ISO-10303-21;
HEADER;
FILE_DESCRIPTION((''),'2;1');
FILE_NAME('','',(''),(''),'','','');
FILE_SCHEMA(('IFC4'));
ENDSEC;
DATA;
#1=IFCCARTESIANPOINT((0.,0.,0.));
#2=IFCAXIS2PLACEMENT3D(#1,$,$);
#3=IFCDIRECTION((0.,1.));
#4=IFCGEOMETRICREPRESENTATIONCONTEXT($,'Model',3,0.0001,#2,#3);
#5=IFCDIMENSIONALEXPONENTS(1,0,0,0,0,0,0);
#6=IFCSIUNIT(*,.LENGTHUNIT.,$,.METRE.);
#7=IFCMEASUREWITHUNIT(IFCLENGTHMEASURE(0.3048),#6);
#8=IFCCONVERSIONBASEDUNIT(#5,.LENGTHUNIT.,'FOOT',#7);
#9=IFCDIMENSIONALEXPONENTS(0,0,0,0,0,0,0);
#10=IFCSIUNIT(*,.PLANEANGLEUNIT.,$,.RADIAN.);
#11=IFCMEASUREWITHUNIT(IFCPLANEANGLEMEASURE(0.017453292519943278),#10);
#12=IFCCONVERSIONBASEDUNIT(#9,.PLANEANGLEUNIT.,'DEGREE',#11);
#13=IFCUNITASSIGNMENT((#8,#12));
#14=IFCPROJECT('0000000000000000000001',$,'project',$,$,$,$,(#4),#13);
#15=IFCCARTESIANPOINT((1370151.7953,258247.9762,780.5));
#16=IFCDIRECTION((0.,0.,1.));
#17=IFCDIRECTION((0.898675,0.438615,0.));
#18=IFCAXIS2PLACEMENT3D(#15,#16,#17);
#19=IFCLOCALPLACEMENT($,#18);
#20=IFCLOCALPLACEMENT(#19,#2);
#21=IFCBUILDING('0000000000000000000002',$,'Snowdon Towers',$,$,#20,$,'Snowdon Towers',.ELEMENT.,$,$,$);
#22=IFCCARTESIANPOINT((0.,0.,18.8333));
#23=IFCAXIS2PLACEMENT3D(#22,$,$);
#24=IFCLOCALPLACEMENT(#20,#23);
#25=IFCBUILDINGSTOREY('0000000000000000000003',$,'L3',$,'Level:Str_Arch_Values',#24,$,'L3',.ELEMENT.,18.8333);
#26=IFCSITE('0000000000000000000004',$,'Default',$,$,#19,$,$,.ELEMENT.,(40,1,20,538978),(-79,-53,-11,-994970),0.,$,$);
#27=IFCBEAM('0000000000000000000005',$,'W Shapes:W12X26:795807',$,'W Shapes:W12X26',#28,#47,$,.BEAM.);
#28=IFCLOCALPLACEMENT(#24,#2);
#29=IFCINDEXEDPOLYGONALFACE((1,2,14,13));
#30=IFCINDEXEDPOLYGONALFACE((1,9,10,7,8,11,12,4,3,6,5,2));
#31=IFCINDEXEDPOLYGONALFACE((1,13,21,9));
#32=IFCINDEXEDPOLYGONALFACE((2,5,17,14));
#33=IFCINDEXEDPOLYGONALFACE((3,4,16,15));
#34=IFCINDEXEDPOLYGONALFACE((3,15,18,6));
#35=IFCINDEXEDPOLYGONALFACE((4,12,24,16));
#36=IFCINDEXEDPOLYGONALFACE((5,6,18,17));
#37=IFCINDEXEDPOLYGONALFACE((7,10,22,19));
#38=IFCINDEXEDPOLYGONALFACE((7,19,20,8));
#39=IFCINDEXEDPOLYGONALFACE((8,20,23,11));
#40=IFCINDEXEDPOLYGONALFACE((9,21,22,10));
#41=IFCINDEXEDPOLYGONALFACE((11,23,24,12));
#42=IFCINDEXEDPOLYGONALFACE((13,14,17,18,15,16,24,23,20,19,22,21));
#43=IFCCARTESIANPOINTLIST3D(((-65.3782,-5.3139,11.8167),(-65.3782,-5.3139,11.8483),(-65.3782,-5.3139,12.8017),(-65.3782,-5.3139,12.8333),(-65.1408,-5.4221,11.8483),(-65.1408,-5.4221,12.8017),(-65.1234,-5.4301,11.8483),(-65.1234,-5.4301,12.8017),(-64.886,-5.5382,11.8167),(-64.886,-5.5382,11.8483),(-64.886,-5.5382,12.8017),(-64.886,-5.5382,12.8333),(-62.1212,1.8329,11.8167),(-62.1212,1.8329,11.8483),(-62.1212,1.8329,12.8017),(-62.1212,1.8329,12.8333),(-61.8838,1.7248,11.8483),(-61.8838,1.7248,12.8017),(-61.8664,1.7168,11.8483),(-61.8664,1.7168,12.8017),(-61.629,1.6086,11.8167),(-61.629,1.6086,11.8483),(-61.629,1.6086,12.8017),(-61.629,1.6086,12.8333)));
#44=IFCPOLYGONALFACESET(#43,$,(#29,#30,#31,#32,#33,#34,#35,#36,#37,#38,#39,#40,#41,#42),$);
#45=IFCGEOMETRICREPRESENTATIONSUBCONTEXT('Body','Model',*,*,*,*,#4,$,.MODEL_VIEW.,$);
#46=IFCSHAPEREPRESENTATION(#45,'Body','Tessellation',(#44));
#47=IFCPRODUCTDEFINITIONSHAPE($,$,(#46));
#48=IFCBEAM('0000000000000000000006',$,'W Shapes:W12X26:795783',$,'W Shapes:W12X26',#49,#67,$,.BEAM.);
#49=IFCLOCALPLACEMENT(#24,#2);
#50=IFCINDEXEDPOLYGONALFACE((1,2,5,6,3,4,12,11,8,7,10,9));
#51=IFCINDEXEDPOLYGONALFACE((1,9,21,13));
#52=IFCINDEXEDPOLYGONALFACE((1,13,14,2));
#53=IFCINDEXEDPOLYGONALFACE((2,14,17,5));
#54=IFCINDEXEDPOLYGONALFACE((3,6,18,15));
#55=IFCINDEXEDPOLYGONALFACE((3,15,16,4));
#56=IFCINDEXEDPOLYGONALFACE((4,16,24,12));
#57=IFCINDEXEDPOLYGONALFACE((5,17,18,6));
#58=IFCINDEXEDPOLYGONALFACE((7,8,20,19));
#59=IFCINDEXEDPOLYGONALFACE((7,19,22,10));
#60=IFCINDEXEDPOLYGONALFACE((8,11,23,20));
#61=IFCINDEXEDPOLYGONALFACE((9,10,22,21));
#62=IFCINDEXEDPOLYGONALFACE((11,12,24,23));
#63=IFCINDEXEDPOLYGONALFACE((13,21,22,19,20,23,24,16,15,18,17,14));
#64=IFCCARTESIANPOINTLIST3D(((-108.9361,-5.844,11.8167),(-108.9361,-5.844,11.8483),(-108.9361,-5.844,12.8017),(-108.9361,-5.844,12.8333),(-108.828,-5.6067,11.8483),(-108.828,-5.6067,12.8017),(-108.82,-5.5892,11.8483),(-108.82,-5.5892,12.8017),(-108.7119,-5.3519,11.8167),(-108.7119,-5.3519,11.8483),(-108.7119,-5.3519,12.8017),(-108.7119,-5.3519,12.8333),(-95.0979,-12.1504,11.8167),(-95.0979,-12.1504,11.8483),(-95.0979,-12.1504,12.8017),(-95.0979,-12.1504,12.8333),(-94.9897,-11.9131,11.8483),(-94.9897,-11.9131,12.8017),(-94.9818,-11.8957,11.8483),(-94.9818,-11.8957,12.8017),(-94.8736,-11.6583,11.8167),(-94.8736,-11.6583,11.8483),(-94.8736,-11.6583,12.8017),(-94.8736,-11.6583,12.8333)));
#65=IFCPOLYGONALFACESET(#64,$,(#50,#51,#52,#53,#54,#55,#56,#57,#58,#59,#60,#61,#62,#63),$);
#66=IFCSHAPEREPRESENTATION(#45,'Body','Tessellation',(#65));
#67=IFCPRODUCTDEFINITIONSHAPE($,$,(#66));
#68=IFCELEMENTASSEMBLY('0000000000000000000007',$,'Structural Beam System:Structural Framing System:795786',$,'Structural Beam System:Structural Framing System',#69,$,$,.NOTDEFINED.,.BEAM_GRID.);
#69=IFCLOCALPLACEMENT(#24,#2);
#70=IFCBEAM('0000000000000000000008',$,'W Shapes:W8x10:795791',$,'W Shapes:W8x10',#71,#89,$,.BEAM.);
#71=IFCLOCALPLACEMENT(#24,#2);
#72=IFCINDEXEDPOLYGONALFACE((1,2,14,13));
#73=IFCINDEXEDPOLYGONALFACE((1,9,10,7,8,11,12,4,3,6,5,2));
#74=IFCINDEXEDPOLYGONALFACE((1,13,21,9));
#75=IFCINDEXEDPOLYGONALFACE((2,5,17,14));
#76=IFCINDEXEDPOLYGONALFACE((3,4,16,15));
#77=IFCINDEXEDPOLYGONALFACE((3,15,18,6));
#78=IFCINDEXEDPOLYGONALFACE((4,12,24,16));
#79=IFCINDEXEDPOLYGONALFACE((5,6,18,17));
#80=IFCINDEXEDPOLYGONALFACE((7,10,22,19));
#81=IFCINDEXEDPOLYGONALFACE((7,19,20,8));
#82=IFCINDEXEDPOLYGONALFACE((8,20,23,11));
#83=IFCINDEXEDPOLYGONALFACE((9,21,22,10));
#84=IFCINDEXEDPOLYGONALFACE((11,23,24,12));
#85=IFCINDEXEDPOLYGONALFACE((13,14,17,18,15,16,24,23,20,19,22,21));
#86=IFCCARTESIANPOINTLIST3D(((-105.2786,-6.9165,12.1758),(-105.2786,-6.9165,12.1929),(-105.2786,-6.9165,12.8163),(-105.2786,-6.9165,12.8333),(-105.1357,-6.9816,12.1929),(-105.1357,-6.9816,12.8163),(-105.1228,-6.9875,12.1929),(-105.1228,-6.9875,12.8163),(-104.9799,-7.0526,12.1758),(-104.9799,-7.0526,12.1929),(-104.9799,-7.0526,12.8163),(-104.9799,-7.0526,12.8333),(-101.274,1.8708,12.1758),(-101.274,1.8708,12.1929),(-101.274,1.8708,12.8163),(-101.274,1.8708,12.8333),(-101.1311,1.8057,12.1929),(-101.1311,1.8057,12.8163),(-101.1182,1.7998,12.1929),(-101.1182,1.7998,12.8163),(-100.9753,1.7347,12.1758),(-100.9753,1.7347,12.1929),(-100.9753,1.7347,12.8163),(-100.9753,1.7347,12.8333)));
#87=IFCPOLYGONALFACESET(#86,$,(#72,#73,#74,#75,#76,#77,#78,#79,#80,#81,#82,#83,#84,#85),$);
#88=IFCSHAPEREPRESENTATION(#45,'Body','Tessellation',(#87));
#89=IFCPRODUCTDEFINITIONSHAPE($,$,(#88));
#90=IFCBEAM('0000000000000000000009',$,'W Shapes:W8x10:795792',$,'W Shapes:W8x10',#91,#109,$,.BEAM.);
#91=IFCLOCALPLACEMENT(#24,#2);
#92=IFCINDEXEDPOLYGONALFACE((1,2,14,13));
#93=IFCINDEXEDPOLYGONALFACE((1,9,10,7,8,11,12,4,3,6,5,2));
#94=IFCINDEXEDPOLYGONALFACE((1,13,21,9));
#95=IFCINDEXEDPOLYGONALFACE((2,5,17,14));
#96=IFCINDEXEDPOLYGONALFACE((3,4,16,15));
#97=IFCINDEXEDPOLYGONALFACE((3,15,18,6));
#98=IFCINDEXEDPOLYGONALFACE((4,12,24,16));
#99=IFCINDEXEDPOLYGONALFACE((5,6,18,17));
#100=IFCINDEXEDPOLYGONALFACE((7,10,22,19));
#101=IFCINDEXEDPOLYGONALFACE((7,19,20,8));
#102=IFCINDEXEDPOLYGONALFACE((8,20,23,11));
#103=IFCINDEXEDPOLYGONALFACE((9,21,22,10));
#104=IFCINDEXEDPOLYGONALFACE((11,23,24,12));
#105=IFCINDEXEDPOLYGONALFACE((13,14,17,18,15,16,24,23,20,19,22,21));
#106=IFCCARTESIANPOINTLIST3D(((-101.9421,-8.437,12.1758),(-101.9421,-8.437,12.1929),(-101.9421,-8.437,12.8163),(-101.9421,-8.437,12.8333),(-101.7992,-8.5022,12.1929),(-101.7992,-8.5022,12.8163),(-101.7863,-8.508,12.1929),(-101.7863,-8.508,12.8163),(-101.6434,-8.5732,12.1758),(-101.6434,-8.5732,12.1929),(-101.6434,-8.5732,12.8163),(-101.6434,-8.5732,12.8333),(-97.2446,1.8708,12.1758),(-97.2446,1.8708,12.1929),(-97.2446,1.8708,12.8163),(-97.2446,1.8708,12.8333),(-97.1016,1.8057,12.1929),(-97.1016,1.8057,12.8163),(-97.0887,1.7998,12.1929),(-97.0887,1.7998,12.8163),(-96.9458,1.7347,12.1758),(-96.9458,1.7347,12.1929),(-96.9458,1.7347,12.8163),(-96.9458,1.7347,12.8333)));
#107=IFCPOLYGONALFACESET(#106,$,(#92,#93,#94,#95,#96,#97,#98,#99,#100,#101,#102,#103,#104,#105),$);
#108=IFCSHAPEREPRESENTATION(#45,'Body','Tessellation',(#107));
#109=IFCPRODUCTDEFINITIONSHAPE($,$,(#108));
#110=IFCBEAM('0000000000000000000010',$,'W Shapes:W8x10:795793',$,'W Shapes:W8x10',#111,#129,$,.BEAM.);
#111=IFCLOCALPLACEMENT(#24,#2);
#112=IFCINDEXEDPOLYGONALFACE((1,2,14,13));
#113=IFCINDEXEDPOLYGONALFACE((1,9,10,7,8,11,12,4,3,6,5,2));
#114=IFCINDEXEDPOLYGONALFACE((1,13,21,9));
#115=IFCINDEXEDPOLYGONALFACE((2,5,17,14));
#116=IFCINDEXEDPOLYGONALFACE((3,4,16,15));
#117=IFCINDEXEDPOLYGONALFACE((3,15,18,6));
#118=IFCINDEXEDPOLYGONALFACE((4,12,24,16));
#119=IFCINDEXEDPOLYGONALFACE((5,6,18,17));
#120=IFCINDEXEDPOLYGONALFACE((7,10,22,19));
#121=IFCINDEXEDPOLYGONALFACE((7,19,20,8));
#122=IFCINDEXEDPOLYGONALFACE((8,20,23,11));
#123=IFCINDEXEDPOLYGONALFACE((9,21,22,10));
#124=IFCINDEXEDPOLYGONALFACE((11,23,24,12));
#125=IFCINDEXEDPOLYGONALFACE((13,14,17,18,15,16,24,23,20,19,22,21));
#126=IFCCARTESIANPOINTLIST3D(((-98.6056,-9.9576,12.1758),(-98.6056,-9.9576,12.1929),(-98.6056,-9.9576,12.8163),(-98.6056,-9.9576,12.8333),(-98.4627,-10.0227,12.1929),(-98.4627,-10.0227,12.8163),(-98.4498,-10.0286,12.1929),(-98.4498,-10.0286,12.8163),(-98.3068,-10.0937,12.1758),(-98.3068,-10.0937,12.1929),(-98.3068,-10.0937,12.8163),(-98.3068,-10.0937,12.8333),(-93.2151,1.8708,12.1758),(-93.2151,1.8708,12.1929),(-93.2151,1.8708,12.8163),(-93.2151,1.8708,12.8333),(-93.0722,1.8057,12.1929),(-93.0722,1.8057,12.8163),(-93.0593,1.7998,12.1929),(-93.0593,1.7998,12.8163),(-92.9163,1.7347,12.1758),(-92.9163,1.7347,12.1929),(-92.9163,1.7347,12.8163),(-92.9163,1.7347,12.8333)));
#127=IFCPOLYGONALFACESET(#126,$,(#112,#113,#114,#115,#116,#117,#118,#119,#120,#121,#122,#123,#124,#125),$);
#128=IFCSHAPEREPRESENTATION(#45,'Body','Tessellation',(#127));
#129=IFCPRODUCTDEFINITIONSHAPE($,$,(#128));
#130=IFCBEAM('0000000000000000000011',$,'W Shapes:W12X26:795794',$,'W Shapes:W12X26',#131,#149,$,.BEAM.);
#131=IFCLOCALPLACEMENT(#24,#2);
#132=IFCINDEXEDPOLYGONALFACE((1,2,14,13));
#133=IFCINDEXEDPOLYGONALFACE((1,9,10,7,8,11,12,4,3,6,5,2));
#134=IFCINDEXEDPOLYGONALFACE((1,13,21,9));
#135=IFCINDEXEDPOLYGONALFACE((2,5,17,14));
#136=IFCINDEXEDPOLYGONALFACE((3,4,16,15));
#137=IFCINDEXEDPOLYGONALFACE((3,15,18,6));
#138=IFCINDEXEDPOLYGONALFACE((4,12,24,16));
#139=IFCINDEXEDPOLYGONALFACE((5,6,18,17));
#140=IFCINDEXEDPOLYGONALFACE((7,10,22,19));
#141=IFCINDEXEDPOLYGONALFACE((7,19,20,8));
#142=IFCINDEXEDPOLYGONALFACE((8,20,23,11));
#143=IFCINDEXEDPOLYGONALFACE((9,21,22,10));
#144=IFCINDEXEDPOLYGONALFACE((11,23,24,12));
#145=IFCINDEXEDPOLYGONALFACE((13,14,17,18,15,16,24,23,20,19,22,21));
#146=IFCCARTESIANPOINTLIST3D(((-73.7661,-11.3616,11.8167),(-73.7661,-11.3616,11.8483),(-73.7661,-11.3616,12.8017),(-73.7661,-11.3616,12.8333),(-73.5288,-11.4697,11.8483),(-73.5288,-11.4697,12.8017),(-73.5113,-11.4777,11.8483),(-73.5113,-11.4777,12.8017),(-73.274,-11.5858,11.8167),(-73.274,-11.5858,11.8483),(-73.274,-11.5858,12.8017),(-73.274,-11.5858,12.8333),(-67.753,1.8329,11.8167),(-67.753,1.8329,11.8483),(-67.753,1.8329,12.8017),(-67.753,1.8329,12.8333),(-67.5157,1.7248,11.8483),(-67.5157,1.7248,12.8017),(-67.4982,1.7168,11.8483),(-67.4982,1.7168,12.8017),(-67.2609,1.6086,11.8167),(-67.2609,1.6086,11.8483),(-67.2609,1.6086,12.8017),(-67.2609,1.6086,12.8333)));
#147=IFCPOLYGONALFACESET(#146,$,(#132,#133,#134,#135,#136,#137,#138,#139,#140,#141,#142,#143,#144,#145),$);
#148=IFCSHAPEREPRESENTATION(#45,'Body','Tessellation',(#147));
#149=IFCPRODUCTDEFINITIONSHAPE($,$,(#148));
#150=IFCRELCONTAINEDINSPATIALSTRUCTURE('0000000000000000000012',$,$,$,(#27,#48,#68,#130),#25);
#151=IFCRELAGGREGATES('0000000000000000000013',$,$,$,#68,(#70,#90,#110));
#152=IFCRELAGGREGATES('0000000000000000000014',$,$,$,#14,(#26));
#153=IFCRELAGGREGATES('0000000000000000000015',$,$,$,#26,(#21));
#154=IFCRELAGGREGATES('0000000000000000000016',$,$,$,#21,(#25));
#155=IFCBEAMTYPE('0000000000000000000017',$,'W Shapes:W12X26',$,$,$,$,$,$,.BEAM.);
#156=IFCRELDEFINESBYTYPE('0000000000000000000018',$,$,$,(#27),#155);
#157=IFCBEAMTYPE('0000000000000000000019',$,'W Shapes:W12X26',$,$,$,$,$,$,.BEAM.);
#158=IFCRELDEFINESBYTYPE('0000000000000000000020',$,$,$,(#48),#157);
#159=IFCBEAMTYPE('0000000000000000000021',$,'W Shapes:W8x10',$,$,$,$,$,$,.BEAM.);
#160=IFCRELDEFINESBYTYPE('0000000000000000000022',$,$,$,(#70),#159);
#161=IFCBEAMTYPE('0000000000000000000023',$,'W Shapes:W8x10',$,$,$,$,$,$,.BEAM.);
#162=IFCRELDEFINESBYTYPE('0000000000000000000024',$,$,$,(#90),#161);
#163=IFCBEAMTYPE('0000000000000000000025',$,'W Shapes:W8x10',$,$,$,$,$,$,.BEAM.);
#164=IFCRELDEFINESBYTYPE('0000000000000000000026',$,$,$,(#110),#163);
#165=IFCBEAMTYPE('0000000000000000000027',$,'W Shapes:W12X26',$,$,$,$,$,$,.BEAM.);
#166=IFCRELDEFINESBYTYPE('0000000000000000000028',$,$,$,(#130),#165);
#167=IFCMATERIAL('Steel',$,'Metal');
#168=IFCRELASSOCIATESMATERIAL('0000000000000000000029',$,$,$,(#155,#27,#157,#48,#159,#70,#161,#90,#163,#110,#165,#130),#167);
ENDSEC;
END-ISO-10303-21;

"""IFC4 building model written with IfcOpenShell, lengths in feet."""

from ifc_helpers import new_model, entity, si_unit, converted_unit, direction, frame, origin, place, context, subcontext, project, spatial, indexed_curve, outline, extrude, source, transform, mapped, material, type_object, type_shapes, element, aggregate, save


model = new_model("IFC4")

# Units and contexts
model_context = context("Model", 3, precision=0.0001, world=origin(), true_north=direction((0.0, 1.0)))
body_context = subcontext(model_context, "Body", "Model", "MODEL_VIEW")
ifc_project = project(units=[converted_unit("LENGTHUNIT", "FOOT", entity("IfcLengthMeasure", 0.3048), si_unit("LENGTHUNIT", "METRE"), dimensions=[1, 0, 0, 0, 0, 0, 0]), converted_unit("PLANEANGLEUNIT", "DEGREE", entity("IfcPlaneAngleMeasure", 0.017453292519943278), si_unit("PLANEANGLEUNIT", "RADIAN"), dimensions=[0, 0, 0, 0, 0, 0, 0])], contexts=[model_context])

# Site, building, storey
site_placement = place(None, frame((1370151.7953, 258247.9762, 780.5), z_axis=(0.0, 0.0, 1.0), x_axis=(0.898675, 0.438615, 0.0)))
site = spatial("IfcSite", under=ifc_project, at=site_placement, Name="Default", CompositionType="ELEMENT", RefLatitude=(40, 1, 20, 538978), RefLongitude=(-79, -53, -11, -994970), RefElevation=0.0)
building_placement = place(site_placement, origin())
building = spatial("IfcBuilding", under=site, at=building_placement, Name="Snowdon Towers", LongName="Snowdon Towers", CompositionType="ELEMENT")
storey_placement = place(building_placement, frame((0.0, 0.0, 18.8333)))
storey = spatial("IfcBuildingStorey", under=building, at=storey_placement, Name="L3", ObjectType="Level:Str_Arch_Values", LongName="L3", CompositionType="ELEMENT", Elevation=18.8333)

# Shared definitions
ifc_material = material(Name="Steel", Category="Metal")

# Beams
beam_type_1 = type_object("IfcBeamType", Name="W Shapes:W12X26", PredefinedType="BEAM", material=ifc_material)
shared_shape_1 = source(origin(), body_context, "Body", "SweptSolid", [
    extrude(outline(indexed_curve([(-0.2704, -0.4767), (-0.2704, -0.5083), (0.2704, -0.5083), (0.2704, -0.4767), (0.0096, -0.4767), (0.0096, 0.4767), (0.2704, 0.4767), (0.2704, 0.5083), (-0.2704, 0.5083), (-0.2704, 0.4767), (-0.0096, 0.4767), (-0.0096, -0.4767), (-0.2704, -0.4767)], self_intersect=False)), frame((-4.1991, 0.0, 0.0), z_axis=(-1.0, 0.0, 0.0), x_axis=(0.0, -1.0, 0.0)), (0.0, 0.0, -1.0), 7.854),
])
type_shapes(beam_type_1, [shared_shape_1])
for number, where, z_axis, x_axis, name in (
    (1, (-63.3907, -1.605, 12.325), (0.0, 0.0, 1.0), (0.414693, 0.909961, 0.0), "W Shapes:W12X26:795807"),
):
    element("IfcBeam", number, at=place(storey_placement, frame(where, z_axis=z_axis, x_axis=x_axis)), inside=storey, type_object=beam_type_1, material=ifc_material, Name=name, ObjectType="W Shapes:W12X26", PredefinedType="BEAM", context=body_context, shape_type="MappedRepresentation", body=[
        mapped(shared_shape_1, transform((0.0, 0.0, 0.0), scale=1.0)),
    ])
beam_type_2 = type_object("IfcBeamType", Name="W Shapes:W12X26", PredefinedType="BEAM", material=ifc_material)
shared_shape_2 = source(origin(), body_context, "Body", "SweptSolid", [
    extrude(outline(indexed_curve([(-0.2704, -0.4767), (-0.2704, -0.5083), (0.2704, -0.5083), (0.2704, -0.4767), (0.0096, -0.4767), (0.0096, 0.4767), (0.2704, 0.4767), (0.2704, 0.5083), (-0.2704, 0.5083), (-0.2704, 0.4767), (-0.0096, 0.4767), (-0.0096, -0.4767), (-0.2704, -0.4767)], self_intersect=False)), frame((-7.6037, 0.0, 0.0), z_axis=(-1.0, 0.0, 0.0), x_axis=(0.0, -1.0, 0.0)), (0.0, 0.0, -1.0), 15.2075),
])
type_shapes(beam_type_2, [shared_shape_2])
beam_1_placement = place(storey_placement, frame((-101.9049, -8.7512, 12.325), z_axis=(0.0, 0.0, 1.0), x_axis=(0.909961, -0.414693, 0.0)))
element("IfcBeam", 2, at=beam_1_placement, inside=storey, type_object=beam_type_2, material=ifc_material, Name="W Shapes:W12X26:795783", ObjectType="W Shapes:W12X26", PredefinedType="BEAM", context=body_context, shape_type="MappedRepresentation", body=[
    mapped(shared_shape_2, transform((0.0, 0.0, 0.0), scale=1.0)),
])

# Element assembly, beams
assembly_1_placement = place(storey_placement, origin())
assembly_1 = element("IfcElementAssembly", 3, at=assembly_1_placement, inside=storey, Name="Structural Beam System:Structural Framing System:795786", ObjectType="Structural Beam System:Structural Framing System", AssemblyPlace="NOTDEFINED", PredefinedType="BEAM_GRID")
beam_type_3 = type_object("IfcBeamType", Name="W Shapes:W8x10", PredefinedType="BEAM", material=ifc_material)
shared_shape_3 = source(origin(), body_context, "Body", "SweptSolid", [
    extrude(outline(indexed_curve([(-0.1642, -0.3117), (-0.1642, -0.3288), (0.1642, -0.3288), (0.1642, -0.3117), (0.0071, -0.3117), (0.0071, 0.3117), (0.1642, 0.3117), (0.1642, 0.3287), (-0.1642, 0.3287), (-0.1642, 0.3117), (-0.0071, 0.3117), (-0.0071, -0.3117), (-0.1642, -0.3117)], self_intersect=False)), frame((-5.0763, 0.0, 0.0), z_axis=(-1.0, 0.0, 0.0), x_axis=(0.0, -1.0, 0.0)), (0.0, 0.0, -1.0), 9.6568),
])
type_shapes(beam_type_3, [shared_shape_3])
beam_2_placement = place(assembly_1_placement, frame((-103.0242, -2.3653, 12.5046), z_axis=(0.0, 0.0, 1.0), x_axis=(0.414693, 0.909961, 0.0)))
beam_2 = element("IfcBeam", 4, at=beam_2_placement, type_object=beam_type_3, material=ifc_material, Name="W Shapes:W8x10:795791", ObjectType="W Shapes:W8x10", PredefinedType="BEAM", context=body_context, shape_type="MappedRepresentation", body=[
    mapped(shared_shape_3, transform((0.0, 0.0, 0.0), scale=1.0)),
])
beam_type_4 = type_object("IfcBeamType", Name="W Shapes:W8x10", PredefinedType="BEAM", material=ifc_material)
shared_shape_4 = source(origin(), body_context, "Body", "SweptSolid", [
    extrude(outline(indexed_curve([(-0.1642, -0.3117), (-0.1642, -0.3288), (0.1642, -0.3288), (0.1642, -0.3117), (0.0071, -0.3117), (0.0071, 0.3117), (0.1642, 0.3117), (0.1642, 0.3287), (-0.1642, 0.3287), (-0.1642, 0.3117), (-0.0071, 0.3117), (-0.0071, -0.3117), (-0.1642, -0.3117)], self_intersect=False)), frame((-5.9118, 0.0, 0.0), z_axis=(-1.0, 0.0, 0.0), x_axis=(0.0, -1.0, 0.0)), (0.0, 0.0, -1.0), 11.3278),
])
type_shapes(beam_type_4, [shared_shape_4])
beam_3_placement = place(assembly_1_placement, frame((-99.3412, -3.1256, 12.5046), z_axis=(0.0, 0.0, 1.0), x_axis=(0.414693, 0.909961, 0.0)))
beam_3 = element("IfcBeam", 5, at=beam_3_placement, type_object=beam_type_4, material=ifc_material, Name="W Shapes:W8x10:795792", ObjectType="W Shapes:W8x10", PredefinedType="BEAM", context=body_context, shape_type="MappedRepresentation", body=[
    mapped(shared_shape_4, transform((0.0, 0.0, 0.0), scale=1.0)),
])
beam_type_5 = type_object("IfcBeamType", Name="W Shapes:W8x10", PredefinedType="BEAM", material=ifc_material)
shared_shape_5 = source(origin(), body_context, "Body", "SweptSolid", [
    extrude(outline(indexed_curve([(-0.1642, -0.3117), (-0.1642, -0.3288), (0.1642, -0.3288), (0.1642, -0.3117), (0.0071, -0.3117), (0.0071, 0.3117), (0.1642, 0.3117), (0.1642, 0.3287), (-0.1642, 0.3287), (-0.1642, 0.3117), (-0.0071, 0.3117), (-0.0071, -0.3117), (-0.1642, -0.3117)], self_intersect=False)), frame((-6.7473, 0.0, 0.0), z_axis=(-1.0, 0.0, 0.0), x_axis=(0.0, -1.0, 0.0)), (0.0, 0.0, -1.0), 12.9988),
])
type_shapes(beam_type_5, [shared_shape_5])
beam_4_placement = place(assembly_1_placement, frame((-95.6582, -3.8858, 12.5046), z_axis=(0.0, 0.0, 1.0), x_axis=(0.414693, 0.909961, 0.0)))
beam_4 = element("IfcBeam", 6, at=beam_4_placement, type_object=beam_type_5, material=ifc_material, Name="W Shapes:W8x10:795793", ObjectType="W Shapes:W8x10", PredefinedType="BEAM", context=body_context, shape_type="MappedRepresentation", body=[
    mapped(shared_shape_5, transform((0.0, 0.0, 0.0), scale=1.0)),
])
aggregate(assembly_1, [beam_2, beam_3, beam_4])

# Beam
beam_type_6 = type_object("IfcBeamType", Name="W Shapes:W12X26", PredefinedType="BEAM", material=ifc_material)
shared_shape_6 = source(origin(), body_context, "Body", "SweptSolid", [
    extrude(outline(indexed_curve([(-0.2704, -0.4767), (-0.2704, -0.5083), (0.2704, -0.5083), (0.2704, -0.4767), (0.0096, -0.4767), (0.0096, 0.4767), (0.2704, 0.4767), (0.2704, 0.5083), (-0.2704, 0.5083), (-0.2704, 0.4767), (-0.0096, 0.4767), (-0.0096, -0.4767), (-0.2704, -0.4767)], self_intersect=False)), frame((-7.5221, 0.0, 0.0), z_axis=(-1.0, 0.0, 0.0), x_axis=(0.0, -1.0, 0.0)), (0.0, 0.0, -1.0), 14.5),
])
type_shapes(beam_type_6, [shared_shape_6])
beam_5_placement = place(storey_placement, frame((-70.4007, -4.6288, 12.325), z_axis=(0.0, 0.0, 1.0), x_axis=(0.414693, 0.909961, 0.0)))
element("IfcBeam", 7, at=beam_5_placement, inside=storey, type_object=beam_type_6, material=ifc_material, Name="W Shapes:W12X26:795794", ObjectType="W Shapes:W12X26", PredefinedType="BEAM", context=body_context, shape_type="MappedRepresentation", body=[
    mapped(shared_shape_6, transform((0.0, 0.0, 0.0), scale=1.0)),
])

save(model, "model.ifc")
